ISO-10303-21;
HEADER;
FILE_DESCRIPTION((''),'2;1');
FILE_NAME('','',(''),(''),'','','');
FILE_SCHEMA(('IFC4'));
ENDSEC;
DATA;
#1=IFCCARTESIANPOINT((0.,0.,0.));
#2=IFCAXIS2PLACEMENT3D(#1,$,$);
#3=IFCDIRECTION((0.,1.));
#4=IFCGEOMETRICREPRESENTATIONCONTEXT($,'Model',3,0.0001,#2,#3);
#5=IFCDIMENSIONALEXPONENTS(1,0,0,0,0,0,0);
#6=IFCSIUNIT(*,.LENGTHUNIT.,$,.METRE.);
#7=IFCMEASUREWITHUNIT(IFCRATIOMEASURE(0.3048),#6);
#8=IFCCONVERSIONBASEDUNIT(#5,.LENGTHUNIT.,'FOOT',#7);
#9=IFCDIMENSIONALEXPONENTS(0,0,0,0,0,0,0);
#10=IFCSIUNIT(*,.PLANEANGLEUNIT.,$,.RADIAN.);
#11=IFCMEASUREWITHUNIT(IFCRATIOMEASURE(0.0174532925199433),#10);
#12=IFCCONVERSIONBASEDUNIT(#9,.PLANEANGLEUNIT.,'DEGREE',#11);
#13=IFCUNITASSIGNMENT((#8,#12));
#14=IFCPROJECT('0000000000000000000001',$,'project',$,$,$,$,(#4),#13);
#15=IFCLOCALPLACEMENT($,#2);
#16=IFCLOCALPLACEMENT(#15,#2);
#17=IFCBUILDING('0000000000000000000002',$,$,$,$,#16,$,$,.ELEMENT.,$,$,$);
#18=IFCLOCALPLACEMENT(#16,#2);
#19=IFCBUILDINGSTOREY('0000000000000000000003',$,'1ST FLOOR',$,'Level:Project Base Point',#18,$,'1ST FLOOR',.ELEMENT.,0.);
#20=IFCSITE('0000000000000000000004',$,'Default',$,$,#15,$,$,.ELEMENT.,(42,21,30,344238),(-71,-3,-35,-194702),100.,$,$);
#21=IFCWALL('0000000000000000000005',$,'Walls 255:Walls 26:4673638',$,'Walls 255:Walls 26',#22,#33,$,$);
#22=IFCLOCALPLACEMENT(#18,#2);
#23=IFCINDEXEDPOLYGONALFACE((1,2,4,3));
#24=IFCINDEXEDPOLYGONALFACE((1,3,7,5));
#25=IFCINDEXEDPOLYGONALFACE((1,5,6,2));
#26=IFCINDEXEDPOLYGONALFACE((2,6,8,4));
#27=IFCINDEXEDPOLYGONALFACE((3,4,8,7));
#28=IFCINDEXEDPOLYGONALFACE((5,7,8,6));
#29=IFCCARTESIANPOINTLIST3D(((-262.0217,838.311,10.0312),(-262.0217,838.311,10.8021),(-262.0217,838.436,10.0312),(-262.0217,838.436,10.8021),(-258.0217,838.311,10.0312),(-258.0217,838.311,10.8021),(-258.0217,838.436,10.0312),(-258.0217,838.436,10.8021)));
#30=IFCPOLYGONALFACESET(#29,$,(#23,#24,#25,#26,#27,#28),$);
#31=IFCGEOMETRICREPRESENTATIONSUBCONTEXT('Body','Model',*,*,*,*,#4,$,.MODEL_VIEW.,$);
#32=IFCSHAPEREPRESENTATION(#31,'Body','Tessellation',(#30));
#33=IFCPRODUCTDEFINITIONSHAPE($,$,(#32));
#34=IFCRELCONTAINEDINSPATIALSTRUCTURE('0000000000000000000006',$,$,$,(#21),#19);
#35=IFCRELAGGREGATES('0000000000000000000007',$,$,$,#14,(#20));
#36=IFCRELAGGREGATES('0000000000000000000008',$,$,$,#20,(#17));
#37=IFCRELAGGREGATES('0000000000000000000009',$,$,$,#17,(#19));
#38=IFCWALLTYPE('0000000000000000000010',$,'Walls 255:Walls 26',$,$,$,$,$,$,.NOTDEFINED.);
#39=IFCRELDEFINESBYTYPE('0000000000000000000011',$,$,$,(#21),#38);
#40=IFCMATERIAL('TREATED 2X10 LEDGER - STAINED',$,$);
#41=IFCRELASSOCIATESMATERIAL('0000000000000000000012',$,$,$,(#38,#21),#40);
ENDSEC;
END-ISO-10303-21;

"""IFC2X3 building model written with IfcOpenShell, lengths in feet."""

from ifc_helpers import new_model, entity, si_unit, converted_unit, direction, frame, origin, origin_2d_with_axis, place, context, subcontext, project, spatial, rectangle, extrude, material, type_object, element, save


model = new_model("IFC2X3")

# Units and contexts
model_context = context("Model", 3, precision=0.0001, world=origin(), true_north=direction((0.0, 1.0)))
body_context = subcontext(model_context, "Body", "Model", "MODEL_VIEW")
ifc_project = project(units=[converted_unit("LENGTHUNIT", "FOOT", entity("IfcRatioMeasure", 0.3048), si_unit("LENGTHUNIT", "METRE"), dimensions=[1, 0, 0, 0, 0, 0, 0]), converted_unit("PLANEANGLEUNIT", "DEGREE", entity("IfcRatioMeasure", 0.0174532925199433), si_unit("PLANEANGLEUNIT", "RADIAN"), dimensions=[0, 0, 0, 0, 0, 0, 0])], contexts=[model_context])

# Site, building, storey
site_placement = place(None, origin())
site = spatial("IfcSite", under=ifc_project, at=site_placement, Name="Default", CompositionType="ELEMENT", RefLatitude=(42, 21, 30, 344238), RefLongitude=(-71, -3, -35, -194702), RefElevation=100.0)
building_placement = place(site_placement, origin())
building = spatial("IfcBuilding", under=site, at=building_placement, CompositionType="ELEMENT")
storey_placement = place(building_placement, origin())
storey = spatial("IfcBuildingStorey", under=building, at=storey_placement, Name="1ST FLOOR", ObjectType="Level:Project Base Point", LongName="1ST FLOOR", CompositionType="ELEMENT", Elevation=0.0)

# Wall
ifc_material_1 = material(Name="TREATED 2X10 LEDGER - STAINED")
wall_type_1 = type_object("IfcWallType", Name="Walls 255:Walls 26", PredefinedType="NOTDEFINED", material=ifc_material_1)
wall_1_placement = place(storey_placement, frame((-262.0217, 838.311, 10.0312)))
element("IfcWall", 1, at=wall_1_placement, inside=storey, type_object=wall_type_1, material=ifc_material_1, Name="Walls 255:Walls 26:4673638", ObjectType="Walls 255:Walls 26", context=body_context, shape_type="SweptSolid", body=[
    extrude(rectangle(XDim=4.0, YDim=0.125, at=origin_2d_with_axis()), frame((2.0, 0.0625, 0.0), z_axis=(0.0, 0.0, 1.0), x_axis=(-1.0, 0.0, 0.0)), (0.0, 0.0, 1.0), 0.7708),
])

save(model, "model.ifc")
